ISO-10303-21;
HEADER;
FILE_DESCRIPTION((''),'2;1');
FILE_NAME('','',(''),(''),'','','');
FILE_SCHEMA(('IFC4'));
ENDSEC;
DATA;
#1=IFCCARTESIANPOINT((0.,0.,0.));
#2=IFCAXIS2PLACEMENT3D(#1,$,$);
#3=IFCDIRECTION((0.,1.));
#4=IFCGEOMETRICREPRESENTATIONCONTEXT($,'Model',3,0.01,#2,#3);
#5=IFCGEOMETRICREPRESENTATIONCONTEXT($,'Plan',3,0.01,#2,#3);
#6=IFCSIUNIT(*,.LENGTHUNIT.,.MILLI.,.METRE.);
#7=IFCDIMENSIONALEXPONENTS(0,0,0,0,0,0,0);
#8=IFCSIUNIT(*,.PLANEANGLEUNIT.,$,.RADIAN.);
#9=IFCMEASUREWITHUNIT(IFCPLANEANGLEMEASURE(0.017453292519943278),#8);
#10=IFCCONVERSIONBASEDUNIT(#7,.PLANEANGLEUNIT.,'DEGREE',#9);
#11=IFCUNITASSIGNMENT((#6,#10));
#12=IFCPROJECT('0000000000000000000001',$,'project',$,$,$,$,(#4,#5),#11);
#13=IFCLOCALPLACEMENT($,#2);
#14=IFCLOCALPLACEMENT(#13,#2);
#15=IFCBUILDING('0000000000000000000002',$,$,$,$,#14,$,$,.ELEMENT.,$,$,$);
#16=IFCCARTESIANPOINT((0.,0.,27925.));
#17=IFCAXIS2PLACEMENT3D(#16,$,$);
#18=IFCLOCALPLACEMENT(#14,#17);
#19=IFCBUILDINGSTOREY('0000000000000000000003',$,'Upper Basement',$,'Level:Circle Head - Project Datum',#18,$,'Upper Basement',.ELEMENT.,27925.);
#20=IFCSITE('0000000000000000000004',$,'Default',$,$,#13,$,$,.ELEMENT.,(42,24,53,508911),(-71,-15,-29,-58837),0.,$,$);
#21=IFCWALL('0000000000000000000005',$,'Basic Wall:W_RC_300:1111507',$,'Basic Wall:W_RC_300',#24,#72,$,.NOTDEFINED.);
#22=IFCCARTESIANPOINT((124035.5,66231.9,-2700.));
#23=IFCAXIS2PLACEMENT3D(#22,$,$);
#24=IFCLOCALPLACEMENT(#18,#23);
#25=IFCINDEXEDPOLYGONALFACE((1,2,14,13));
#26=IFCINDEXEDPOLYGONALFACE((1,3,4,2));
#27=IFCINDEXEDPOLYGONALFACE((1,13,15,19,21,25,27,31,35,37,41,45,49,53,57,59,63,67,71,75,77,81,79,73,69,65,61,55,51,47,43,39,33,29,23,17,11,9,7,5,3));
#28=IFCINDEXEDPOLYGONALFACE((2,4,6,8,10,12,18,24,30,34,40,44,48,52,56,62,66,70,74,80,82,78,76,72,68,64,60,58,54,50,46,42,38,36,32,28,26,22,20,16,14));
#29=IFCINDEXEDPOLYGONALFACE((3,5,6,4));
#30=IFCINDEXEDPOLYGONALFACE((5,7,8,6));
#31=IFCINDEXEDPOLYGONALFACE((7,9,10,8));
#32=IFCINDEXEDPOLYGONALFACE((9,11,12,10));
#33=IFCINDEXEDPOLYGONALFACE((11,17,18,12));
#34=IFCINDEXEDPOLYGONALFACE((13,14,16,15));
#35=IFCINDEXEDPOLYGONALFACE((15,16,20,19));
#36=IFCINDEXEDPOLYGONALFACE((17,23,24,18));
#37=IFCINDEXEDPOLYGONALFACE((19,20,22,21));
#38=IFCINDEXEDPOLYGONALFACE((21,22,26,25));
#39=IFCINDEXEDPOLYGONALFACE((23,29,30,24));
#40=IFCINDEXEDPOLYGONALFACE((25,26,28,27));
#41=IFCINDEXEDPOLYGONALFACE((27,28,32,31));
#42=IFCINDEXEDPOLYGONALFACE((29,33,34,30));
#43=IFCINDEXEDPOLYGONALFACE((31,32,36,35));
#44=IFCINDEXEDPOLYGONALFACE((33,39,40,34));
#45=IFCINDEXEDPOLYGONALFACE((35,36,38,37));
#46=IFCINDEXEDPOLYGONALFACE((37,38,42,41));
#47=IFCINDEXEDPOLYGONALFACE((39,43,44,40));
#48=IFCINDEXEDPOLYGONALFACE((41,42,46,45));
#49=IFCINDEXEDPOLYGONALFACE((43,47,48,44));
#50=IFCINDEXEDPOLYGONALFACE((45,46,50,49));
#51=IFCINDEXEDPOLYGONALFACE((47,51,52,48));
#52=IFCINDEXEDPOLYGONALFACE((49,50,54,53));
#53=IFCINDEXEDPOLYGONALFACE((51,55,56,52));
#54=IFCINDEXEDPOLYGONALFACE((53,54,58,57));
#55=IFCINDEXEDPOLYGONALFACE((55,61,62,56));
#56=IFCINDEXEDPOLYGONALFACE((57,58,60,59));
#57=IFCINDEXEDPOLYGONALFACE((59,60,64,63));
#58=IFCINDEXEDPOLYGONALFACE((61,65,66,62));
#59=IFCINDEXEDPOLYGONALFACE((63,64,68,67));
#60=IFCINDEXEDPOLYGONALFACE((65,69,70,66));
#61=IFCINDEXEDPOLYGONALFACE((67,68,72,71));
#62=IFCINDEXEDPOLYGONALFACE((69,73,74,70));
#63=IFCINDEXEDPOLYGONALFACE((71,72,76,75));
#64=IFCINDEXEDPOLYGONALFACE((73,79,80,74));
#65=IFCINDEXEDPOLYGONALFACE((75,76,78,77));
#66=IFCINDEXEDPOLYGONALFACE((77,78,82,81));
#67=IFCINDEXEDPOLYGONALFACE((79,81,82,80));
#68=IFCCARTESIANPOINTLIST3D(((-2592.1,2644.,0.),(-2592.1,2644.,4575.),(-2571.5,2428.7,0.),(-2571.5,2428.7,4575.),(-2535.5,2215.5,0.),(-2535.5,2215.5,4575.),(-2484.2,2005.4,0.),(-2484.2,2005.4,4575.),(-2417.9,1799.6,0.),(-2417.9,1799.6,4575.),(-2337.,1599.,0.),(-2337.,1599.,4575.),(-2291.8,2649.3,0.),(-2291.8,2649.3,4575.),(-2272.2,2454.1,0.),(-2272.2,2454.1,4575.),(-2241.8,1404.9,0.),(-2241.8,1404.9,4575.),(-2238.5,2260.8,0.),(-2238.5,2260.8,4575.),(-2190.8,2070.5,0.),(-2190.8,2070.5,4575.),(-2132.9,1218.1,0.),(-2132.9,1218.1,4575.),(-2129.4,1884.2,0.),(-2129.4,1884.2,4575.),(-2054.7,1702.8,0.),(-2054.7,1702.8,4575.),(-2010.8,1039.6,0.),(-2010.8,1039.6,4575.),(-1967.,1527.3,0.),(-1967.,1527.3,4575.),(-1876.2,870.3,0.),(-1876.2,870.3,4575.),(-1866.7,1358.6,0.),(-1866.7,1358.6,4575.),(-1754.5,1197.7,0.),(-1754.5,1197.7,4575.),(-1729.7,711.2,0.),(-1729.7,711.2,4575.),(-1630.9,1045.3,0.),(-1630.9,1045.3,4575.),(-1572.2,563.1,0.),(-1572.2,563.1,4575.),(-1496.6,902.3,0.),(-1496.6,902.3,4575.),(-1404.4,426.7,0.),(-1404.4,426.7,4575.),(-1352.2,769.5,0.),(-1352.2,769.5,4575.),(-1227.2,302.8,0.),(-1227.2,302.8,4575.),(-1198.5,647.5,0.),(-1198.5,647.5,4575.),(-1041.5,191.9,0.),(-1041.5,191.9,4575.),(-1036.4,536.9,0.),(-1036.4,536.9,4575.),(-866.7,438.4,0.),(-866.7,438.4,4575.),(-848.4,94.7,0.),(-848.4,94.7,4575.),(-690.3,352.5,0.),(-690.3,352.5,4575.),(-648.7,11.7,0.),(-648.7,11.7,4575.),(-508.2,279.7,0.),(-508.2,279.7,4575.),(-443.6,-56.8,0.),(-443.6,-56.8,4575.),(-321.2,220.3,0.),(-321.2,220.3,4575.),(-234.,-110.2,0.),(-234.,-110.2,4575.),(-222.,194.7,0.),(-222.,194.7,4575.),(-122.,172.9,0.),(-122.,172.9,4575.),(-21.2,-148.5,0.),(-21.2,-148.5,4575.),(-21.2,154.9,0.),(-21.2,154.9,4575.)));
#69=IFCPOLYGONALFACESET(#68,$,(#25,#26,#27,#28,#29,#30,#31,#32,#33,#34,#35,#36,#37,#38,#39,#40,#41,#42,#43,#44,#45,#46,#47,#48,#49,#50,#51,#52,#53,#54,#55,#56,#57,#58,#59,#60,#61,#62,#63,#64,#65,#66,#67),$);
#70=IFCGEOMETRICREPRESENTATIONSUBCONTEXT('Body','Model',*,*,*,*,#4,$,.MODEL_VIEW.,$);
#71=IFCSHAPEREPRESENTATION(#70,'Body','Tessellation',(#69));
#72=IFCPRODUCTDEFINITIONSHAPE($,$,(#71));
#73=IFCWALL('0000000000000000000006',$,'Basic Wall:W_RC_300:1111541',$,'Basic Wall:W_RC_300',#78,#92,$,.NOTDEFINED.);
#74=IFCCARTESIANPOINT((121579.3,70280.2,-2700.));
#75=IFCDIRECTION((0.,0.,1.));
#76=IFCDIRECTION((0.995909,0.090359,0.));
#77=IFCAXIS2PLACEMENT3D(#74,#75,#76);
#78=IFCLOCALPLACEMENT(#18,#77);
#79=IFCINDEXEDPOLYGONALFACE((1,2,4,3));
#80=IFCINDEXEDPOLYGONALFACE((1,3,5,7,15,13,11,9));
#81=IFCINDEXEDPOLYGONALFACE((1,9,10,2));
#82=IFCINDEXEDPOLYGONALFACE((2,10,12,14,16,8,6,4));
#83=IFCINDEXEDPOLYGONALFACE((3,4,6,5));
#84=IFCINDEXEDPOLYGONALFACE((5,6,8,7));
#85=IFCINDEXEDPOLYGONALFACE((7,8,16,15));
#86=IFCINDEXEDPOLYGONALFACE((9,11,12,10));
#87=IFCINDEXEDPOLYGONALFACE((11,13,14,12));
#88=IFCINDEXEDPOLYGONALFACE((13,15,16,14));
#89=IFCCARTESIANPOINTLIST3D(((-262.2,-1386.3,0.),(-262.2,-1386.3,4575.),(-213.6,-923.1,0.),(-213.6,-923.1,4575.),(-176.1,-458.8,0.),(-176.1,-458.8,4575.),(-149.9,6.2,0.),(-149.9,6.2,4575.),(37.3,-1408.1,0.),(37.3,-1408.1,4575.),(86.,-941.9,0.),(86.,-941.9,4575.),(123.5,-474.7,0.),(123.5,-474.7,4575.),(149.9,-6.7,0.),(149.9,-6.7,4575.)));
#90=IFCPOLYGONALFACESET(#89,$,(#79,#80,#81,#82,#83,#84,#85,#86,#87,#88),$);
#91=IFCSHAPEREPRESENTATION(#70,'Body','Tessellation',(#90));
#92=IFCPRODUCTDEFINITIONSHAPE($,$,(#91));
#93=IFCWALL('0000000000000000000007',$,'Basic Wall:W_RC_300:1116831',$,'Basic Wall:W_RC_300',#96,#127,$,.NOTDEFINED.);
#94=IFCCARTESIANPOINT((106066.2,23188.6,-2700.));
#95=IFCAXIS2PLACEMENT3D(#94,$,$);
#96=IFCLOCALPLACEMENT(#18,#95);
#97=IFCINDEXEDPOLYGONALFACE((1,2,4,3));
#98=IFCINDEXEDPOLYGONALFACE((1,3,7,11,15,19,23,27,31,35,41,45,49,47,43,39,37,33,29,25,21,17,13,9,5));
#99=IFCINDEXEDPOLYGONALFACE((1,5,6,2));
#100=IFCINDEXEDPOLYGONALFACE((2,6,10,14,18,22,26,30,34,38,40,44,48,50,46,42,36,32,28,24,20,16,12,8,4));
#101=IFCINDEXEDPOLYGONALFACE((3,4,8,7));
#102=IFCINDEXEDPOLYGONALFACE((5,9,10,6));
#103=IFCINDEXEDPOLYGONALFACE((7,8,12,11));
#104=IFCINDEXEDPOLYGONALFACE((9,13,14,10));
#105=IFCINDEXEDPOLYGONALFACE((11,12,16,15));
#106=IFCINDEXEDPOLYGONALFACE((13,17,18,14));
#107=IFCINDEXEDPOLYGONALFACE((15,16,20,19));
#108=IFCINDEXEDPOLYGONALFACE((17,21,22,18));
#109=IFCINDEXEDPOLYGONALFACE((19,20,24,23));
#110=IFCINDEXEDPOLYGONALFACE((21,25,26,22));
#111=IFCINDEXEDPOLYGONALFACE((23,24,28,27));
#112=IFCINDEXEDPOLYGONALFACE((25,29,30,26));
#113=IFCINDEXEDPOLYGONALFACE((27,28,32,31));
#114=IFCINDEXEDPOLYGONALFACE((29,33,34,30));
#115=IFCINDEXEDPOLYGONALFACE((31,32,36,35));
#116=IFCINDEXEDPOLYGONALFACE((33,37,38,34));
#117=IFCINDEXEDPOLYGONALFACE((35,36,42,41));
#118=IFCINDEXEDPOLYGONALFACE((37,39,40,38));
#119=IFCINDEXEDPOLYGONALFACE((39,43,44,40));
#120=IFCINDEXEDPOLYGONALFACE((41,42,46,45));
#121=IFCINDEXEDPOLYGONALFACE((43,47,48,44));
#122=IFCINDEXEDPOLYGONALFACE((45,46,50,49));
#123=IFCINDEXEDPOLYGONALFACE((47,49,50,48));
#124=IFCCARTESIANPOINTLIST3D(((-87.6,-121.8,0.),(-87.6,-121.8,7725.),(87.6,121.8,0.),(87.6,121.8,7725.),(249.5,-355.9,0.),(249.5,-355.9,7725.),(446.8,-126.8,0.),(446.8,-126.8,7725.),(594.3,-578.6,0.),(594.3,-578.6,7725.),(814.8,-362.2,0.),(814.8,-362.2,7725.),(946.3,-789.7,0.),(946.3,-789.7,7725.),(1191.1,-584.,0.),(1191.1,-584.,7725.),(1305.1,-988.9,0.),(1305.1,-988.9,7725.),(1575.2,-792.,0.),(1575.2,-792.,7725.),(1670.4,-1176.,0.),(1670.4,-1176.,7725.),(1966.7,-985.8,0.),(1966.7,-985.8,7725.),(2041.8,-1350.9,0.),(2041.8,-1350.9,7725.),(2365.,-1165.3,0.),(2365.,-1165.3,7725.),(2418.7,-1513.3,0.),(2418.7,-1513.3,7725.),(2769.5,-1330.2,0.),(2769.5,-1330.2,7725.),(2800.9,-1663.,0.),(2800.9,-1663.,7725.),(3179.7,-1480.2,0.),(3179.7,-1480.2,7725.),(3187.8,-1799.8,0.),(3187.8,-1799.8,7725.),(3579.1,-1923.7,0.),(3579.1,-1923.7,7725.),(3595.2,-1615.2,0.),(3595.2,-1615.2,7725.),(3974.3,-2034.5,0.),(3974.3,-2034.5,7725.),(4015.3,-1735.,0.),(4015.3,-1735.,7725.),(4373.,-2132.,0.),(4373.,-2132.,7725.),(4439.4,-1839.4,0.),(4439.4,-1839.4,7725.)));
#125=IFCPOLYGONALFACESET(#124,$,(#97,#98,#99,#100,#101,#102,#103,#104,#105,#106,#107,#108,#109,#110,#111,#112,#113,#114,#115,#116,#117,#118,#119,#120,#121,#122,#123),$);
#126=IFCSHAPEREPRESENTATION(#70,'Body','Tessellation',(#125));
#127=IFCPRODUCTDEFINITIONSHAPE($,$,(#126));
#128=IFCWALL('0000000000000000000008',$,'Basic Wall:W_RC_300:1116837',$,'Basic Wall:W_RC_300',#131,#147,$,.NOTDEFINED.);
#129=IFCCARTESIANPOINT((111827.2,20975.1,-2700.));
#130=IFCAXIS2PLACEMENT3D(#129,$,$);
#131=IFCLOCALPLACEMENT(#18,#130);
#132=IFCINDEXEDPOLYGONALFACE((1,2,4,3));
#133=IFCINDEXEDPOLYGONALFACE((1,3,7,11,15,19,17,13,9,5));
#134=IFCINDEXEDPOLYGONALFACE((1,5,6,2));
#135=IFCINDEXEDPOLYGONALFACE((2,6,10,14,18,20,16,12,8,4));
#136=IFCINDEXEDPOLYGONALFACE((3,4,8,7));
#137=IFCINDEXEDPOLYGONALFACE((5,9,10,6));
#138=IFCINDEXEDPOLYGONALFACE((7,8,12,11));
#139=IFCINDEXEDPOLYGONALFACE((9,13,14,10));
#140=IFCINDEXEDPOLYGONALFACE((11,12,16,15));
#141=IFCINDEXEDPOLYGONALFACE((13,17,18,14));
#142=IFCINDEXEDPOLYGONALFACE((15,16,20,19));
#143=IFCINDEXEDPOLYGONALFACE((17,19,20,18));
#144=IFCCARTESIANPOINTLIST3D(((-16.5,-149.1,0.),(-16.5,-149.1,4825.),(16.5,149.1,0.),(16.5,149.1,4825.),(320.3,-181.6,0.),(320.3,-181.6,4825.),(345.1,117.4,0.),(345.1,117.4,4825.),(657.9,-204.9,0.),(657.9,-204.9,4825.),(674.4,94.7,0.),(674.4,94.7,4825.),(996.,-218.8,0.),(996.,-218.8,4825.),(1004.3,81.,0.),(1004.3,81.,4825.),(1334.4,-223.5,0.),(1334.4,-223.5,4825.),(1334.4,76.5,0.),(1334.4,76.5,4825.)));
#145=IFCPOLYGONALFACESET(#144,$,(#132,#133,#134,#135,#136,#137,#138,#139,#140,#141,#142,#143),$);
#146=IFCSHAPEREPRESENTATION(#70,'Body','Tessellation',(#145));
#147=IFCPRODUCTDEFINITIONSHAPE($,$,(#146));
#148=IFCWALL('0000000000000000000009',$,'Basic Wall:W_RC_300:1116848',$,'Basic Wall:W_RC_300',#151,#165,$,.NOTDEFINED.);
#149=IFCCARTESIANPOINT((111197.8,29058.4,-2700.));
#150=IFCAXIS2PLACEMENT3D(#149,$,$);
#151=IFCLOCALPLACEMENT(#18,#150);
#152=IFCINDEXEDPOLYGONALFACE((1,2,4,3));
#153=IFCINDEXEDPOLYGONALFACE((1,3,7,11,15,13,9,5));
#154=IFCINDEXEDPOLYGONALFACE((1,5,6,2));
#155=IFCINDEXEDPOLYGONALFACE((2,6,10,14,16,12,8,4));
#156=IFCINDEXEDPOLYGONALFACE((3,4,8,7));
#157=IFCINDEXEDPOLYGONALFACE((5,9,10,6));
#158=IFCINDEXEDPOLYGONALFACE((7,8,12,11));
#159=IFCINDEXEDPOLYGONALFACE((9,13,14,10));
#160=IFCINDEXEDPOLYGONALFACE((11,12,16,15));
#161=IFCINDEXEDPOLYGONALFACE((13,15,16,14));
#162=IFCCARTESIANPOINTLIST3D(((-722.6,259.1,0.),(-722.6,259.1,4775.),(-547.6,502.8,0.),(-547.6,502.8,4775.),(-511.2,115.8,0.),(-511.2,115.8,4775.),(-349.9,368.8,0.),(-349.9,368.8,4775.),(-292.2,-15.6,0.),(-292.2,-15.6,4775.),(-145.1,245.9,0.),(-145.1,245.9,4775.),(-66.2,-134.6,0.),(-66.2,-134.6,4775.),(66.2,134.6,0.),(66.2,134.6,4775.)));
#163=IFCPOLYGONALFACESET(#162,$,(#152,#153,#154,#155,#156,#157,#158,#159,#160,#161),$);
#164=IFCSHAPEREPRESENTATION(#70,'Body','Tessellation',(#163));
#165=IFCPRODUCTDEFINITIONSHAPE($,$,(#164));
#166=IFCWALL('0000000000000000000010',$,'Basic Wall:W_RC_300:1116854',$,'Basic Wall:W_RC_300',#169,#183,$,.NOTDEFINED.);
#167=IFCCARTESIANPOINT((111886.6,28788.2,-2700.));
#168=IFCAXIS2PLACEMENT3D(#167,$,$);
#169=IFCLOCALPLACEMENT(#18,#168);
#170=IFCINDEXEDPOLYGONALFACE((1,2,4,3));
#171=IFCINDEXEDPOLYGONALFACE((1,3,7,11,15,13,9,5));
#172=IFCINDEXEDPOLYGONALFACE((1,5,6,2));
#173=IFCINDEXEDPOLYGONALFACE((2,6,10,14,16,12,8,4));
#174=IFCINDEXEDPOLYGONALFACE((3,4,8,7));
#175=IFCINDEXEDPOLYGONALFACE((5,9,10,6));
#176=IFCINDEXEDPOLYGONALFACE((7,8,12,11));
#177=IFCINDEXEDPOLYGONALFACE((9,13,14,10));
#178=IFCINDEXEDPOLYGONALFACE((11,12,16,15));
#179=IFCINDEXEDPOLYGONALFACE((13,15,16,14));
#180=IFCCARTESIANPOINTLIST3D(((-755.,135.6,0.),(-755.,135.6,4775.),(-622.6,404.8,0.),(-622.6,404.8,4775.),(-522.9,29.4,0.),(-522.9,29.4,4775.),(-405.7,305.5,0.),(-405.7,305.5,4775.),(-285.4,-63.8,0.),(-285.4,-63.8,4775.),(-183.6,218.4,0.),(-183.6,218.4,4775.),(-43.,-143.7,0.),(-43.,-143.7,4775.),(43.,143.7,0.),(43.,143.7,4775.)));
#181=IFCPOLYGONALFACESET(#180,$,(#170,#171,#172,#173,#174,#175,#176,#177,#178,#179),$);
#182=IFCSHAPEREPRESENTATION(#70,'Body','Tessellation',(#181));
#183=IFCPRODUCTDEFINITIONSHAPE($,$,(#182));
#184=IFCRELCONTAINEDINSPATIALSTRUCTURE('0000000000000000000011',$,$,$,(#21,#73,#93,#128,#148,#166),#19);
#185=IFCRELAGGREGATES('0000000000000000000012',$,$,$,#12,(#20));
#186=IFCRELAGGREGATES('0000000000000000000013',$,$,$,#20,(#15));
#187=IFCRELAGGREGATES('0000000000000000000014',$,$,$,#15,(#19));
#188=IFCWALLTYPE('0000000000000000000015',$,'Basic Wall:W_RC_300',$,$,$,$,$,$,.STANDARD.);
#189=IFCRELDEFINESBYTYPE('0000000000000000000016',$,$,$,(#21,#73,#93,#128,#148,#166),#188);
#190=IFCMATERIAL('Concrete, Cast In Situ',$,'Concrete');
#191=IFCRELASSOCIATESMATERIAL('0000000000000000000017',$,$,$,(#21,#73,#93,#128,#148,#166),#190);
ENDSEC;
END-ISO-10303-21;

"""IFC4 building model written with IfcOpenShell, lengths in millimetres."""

from ifc_helpers import new_model, entity, si_unit, converted_unit, direction, frame, origin, place, context, subcontext, project, spatial, line, arc, indexed_curve, outline, extrude, material, type_object, element, save


model = new_model("IFC4")

# Units and contexts
model_context = context("Model", 3, precision=0.01, world=origin(), true_north=direction((0.0, 1.0)))
plan_context = context("Plan", 3, precision=0.01, world=origin(), true_north=direction((0.0, 1.0)))
body_context = subcontext(model_context, "Body", "Model", "MODEL_VIEW")
ifc_project = project(units=[si_unit("LENGTHUNIT", "METRE", prefix="MILLI"), converted_unit("PLANEANGLEUNIT", "DEGREE", entity("IfcPlaneAngleMeasure", 0.017453292519943278), si_unit("PLANEANGLEUNIT", "RADIAN"), dimensions=[0, 0, 0, 0, 0, 0, 0])], contexts=[model_context, plan_context])

# Site, building, storey
site_placement = place(None, origin())
site = spatial("IfcSite", under=ifc_project, at=site_placement, Name="Default", CompositionType="ELEMENT", RefLatitude=(42, 24, 53, 508911), RefLongitude=(-71, -15, -29, -58837), RefElevation=0.0)
building_placement = place(site_placement, origin())
building = spatial("IfcBuilding", under=site, at=building_placement, CompositionType="ELEMENT")
storey_placement = place(building_placement, frame((0.0, 0.0, 27925.0)))
storey = spatial("IfcBuildingStorey", under=building, at=storey_placement, Name="Upper Basement", ObjectType="Level:Circle Head - Project Datum", LongName="Upper Basement", CompositionType="ELEMENT", Elevation=27925.0)

# Walls
ifc_material_1 = material(Name="Concrete, Cast In Situ", Category="Concrete")
wall_type = type_object("IfcWallType", Name="Basic Wall:W_RC_300", PredefinedType="STANDARD")
wall_1_placement = place(storey_placement, frame((124035.5, 66231.9, -2700.0)))
element("IfcWall", 1, at=wall_1_placement, inside=storey, type_object=wall_type, material=ifc_material_1, Name="Basic Wall:W_RC_300:1111507", ObjectType="Basic Wall:W_RC_300", PredefinedType="NOTDEFINED", context=body_context, shape_type="SweptSolid", body=[
    extrude(outline(indexed_curve([(-2592.1, 2644.0), (-1804.4, 789.5), (-21.2, -148.5), (-21.2, 154.9), (-172.1, 183.3), (-321.2, 220.3), (-1694.1, 1120.4), (-2291.8, 2649.3)], segments=[arc(1, 2, 3), line(3, 4), arc(4, 5, 6), arc(6, 7, 8), line(8, 1)], self_intersect=False)), origin(), (0.0, 0.0, 1.0), 4575.0),
])
wall_2_placement = place(storey_placement, frame((121579.3, 70280.2, -2700.0), z_axis=(0.0, 0.0, 1.0), x_axis=(0.995909, 0.090359, 0.0)))
element("IfcWall", 2, at=wall_2_placement, inside=storey, type_object=wall_type, material=ifc_material_1, Name="Basic Wall:W_RC_300:1111541", ObjectType="Basic Wall:W_RC_300", PredefinedType="NOTDEFINED", context=body_context, shape_type="SweptSolid", body=[
    extrude(outline(indexed_curve([(37.3, -1408.1), (106.1, -708.4), (149.9, -6.7), (-149.9, 6.2), (-193.5, -691.1), (-262.2, -1386.3)], segments=[arc(1, 2, 3), line(3, 4), arc(4, 5, 6), line(6, 1)], self_intersect=False)), origin(), (0.0, 0.0, 1.0), 4575.0),
])
wall_3_placement = place(storey_placement, frame((106066.2, 23188.6, -2700.0)))
element("IfcWall", 3, at=wall_3_placement, inside=storey, type_object=wall_type, material=ifc_material_1, Name="Basic Wall:W_RC_300:1116831", ObjectType="Basic Wall:W_RC_300", PredefinedType="NOTDEFINED", context=body_context, shape_type="SweptSolid", body=[
    extrude(outline(indexed_curve([(4439.4, -1839.4), (2165.0, -1077.4), (87.6, 121.8), (-87.6, -121.8), (2041.8, -1350.9), (4373.0, -2132.0)], segments=[arc(1, 2, 3), line(3, 4), arc(4, 5, 6), line(6, 1)], self_intersect=False)), origin(), (0.0, 0.0, 1.0), 7725.0),
])
wall_4_placement = place(storey_placement, frame((111827.2, 20975.1, -2700.0)))
element("IfcWall", 4, at=wall_4_placement, inside=storey, type_object=wall_type, material=ifc_material_1, Name="Basic Wall:W_RC_300:1116837", ObjectType="Basic Wall:W_RC_300", PredefinedType="NOTDEFINED", context=body_context, shape_type="SweptSolid", body=[
    extrude(outline(indexed_curve([(1334.4, 76.5), (674.4, 94.7), (16.5, 149.1), (-16.5, -149.1), (657.9, -204.9), (1334.4, -223.5)], segments=[arc(1, 2, 3), line(3, 4), arc(4, 5, 6), line(6, 1)], self_intersect=False)), origin(), (0.0, 0.0, 1.0), 4825.0),
])
wall_5_placement = place(storey_placement, frame((111197.8, 29058.4, -2700.0)))
element("IfcWall", 5, at=wall_5_placement, inside=storey, type_object=wall_type, material=ifc_material_1, Name="Basic Wall:W_RC_300:1116848", ObjectType="Basic Wall:W_RC_300", PredefinedType="NOTDEFINED", context=body_context, shape_type="SweptSolid", body=[
    extrude(outline(indexed_curve([(-722.6, 259.1), (-402.6, 48.6), (-66.2, -134.6), (66.2, 134.6), (-248.4, 305.9), (-547.6, 502.8)], segments=[arc(1, 2, 3), line(3, 4), arc(4, 5, 6), line(6, 1)], self_intersect=False)), origin(), (0.0, 0.0, 1.0), 4775.0),
])
wall_6_placement = place(storey_placement, frame((111886.6, 28788.2, -2700.0)))
element("IfcWall", 6, at=wall_6_placement, inside=storey, type_object=wall_type, material=ifc_material_1, Name="Basic Wall:W_RC_300:1116854", ObjectType="Basic Wall:W_RC_300", PredefinedType="NOTDEFINED", context=body_context, shape_type="SweptSolid", body=[
    extrude(outline(indexed_curve([(-755.0, 135.6), (-404.8, -18.9), (-43.0, -143.7), (43.0, 143.7), (-295.3, 260.4), (-622.6, 404.8)], segments=[arc(1, 2, 3), line(3, 4), arc(4, 5, 6), line(6, 1)], self_intersect=False)), origin(), (0.0, 0.0, 1.0), 4775.0),
])

save(model, "model.ifc")
